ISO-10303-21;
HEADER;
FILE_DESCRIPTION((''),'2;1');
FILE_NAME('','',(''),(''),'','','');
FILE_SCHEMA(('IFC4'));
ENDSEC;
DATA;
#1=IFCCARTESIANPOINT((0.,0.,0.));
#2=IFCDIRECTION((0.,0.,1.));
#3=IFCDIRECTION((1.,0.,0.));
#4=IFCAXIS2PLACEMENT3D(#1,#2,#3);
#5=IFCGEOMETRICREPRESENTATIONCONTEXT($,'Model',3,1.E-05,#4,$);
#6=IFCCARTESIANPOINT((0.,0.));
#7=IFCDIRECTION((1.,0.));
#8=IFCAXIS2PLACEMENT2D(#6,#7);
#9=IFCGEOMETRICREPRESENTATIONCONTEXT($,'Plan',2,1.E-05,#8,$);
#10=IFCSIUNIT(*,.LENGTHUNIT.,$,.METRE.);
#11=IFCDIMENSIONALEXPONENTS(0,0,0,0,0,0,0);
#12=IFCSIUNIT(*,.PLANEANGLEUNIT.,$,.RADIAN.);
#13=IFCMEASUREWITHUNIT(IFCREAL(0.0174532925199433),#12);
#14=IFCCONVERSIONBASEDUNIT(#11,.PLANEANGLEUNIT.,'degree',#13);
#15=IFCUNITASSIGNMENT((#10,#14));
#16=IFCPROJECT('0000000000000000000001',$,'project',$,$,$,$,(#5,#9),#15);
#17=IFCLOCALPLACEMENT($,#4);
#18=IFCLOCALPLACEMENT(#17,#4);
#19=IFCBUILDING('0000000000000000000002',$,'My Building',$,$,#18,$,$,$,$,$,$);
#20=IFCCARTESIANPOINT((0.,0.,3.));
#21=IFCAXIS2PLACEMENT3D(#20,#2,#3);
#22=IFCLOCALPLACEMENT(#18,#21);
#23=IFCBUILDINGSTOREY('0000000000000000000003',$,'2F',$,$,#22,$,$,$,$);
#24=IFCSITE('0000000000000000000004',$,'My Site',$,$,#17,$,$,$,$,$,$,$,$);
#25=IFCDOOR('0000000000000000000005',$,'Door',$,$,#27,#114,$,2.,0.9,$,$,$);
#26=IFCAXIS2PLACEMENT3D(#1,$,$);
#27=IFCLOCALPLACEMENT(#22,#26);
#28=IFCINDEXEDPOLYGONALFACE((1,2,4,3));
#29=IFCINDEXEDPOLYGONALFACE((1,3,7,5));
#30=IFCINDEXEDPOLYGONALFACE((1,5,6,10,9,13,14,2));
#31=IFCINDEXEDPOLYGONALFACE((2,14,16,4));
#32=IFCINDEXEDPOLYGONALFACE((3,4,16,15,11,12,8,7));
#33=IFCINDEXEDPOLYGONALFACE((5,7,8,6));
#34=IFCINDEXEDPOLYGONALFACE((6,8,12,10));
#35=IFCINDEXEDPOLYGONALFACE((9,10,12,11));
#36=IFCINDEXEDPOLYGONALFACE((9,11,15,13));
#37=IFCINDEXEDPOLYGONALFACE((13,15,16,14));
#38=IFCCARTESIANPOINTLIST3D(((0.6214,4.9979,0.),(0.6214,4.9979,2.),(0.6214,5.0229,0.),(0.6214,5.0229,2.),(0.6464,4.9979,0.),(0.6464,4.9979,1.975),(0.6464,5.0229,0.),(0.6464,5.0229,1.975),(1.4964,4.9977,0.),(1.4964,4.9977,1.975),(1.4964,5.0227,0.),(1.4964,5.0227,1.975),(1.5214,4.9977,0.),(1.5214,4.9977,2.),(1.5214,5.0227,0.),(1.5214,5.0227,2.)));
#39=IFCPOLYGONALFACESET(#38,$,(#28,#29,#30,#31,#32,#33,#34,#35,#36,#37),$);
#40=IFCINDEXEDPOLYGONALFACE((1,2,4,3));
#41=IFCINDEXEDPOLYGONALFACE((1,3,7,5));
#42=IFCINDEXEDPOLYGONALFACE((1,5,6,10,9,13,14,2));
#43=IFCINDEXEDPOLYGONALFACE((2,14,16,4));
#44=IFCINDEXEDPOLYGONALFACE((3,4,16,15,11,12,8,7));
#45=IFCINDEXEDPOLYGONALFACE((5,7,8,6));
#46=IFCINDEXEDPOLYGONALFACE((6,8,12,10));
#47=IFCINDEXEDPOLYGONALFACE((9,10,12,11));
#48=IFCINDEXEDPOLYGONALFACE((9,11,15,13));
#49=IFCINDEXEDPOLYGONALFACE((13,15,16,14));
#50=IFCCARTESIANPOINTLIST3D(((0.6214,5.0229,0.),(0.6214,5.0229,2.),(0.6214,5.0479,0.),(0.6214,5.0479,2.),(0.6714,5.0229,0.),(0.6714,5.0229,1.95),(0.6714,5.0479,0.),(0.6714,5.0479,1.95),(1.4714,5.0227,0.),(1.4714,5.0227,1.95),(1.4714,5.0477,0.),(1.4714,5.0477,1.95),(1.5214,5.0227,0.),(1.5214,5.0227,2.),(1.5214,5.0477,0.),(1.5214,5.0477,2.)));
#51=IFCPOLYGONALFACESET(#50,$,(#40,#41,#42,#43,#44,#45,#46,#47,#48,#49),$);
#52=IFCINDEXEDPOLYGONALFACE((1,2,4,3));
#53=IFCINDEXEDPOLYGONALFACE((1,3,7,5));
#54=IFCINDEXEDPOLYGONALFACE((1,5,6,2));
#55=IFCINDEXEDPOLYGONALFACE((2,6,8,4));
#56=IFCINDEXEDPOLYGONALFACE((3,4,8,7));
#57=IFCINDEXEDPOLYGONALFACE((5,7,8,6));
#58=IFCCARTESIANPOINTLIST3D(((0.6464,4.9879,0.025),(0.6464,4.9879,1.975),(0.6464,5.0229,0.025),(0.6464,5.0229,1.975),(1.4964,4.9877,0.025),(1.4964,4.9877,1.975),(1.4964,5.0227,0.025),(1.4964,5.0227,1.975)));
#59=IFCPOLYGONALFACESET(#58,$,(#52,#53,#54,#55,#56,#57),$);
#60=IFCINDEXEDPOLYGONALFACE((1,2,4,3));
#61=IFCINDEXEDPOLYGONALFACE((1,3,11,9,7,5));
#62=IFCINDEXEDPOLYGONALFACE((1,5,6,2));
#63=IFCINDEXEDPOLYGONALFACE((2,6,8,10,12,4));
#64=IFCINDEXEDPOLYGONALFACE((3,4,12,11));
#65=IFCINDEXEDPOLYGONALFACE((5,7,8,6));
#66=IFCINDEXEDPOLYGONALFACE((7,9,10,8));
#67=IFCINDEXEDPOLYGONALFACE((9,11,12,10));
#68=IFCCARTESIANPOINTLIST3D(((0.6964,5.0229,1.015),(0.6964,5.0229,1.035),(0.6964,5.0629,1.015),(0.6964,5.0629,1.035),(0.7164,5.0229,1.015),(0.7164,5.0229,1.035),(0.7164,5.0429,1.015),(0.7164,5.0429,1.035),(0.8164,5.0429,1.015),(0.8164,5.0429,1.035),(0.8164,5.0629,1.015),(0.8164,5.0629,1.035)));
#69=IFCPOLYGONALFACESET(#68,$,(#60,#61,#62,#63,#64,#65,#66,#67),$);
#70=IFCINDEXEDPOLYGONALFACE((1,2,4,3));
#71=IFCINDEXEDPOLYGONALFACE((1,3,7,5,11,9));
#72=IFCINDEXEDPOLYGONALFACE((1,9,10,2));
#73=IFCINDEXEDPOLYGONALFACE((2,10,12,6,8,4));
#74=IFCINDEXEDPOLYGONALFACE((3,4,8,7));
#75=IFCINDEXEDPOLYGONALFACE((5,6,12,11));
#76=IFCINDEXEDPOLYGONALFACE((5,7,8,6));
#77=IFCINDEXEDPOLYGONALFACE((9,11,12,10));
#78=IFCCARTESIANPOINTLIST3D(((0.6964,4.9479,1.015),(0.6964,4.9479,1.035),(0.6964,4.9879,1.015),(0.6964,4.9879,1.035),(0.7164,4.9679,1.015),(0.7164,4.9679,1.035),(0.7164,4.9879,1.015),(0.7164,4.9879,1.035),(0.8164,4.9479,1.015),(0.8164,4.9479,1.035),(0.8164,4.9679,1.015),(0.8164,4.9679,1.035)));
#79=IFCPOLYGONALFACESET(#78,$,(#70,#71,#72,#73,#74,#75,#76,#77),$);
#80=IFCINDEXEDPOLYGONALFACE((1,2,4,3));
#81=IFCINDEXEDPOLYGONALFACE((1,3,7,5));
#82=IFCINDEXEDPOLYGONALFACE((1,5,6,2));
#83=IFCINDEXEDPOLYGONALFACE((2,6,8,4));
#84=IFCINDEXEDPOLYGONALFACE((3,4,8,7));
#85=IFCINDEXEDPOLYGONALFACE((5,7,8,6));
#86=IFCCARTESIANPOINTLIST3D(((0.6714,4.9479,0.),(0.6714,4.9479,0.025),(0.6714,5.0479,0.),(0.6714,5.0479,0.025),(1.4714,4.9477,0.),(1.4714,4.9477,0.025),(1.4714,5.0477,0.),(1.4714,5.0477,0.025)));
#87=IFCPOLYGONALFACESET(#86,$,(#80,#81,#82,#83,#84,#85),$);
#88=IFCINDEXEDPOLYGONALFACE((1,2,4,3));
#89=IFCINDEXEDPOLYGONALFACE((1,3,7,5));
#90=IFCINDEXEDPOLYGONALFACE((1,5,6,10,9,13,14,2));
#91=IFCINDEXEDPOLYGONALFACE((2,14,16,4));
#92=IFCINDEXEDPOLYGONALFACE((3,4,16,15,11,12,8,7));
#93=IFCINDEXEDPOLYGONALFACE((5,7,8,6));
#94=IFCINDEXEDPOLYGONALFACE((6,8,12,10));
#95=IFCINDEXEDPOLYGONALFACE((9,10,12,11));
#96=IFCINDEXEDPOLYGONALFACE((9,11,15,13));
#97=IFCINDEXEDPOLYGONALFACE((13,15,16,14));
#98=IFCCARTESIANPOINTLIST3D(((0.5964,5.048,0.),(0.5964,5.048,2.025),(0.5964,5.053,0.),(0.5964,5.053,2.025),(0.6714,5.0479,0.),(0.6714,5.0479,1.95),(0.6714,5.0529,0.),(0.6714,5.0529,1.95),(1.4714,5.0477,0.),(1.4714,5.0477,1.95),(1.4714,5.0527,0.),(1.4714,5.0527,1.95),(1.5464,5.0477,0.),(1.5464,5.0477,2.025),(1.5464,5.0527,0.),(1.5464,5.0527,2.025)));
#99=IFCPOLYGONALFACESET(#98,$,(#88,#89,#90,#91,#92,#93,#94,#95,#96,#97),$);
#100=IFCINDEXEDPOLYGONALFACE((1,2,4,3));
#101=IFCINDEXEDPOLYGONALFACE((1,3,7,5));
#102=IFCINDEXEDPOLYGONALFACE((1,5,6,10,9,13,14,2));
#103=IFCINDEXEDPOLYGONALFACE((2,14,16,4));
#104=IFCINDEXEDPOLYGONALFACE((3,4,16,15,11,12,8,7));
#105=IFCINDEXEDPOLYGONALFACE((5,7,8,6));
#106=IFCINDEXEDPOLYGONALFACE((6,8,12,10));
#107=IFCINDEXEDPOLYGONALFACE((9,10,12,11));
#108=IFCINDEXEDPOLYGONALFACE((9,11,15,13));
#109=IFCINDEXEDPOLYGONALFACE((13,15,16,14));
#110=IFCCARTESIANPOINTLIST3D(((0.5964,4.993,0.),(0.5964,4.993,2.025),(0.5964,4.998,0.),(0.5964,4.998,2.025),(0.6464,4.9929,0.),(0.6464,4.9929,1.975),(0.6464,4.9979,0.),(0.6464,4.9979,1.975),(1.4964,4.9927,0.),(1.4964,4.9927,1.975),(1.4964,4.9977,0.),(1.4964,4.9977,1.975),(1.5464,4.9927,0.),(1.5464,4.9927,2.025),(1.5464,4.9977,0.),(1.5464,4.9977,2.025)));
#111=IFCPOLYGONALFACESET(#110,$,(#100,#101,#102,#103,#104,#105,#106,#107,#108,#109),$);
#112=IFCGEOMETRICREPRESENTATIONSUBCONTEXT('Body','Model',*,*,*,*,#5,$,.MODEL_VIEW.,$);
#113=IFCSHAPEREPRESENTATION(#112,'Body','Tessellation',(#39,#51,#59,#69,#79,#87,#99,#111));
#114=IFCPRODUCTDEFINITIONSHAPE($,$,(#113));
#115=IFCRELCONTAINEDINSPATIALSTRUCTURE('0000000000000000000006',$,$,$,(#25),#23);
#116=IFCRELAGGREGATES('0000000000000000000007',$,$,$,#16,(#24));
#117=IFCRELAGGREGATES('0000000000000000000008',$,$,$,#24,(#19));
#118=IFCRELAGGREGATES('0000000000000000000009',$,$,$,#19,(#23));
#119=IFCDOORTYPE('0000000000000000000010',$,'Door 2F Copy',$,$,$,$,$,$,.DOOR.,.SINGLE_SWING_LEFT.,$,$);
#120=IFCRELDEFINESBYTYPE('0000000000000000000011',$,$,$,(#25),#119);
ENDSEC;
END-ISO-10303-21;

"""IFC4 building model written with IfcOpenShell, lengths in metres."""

from ifc_helpers import new_model, entity, si_unit, converted_unit, frame, origin_with_axes, origin_2d_with_axis, place, context, subcontext, project, spatial, line, indexed_curve, outline, extrude, shape, source, transform, mapped, type_object, type_shapes, element, save


model = new_model("IFC4")

# Units and contexts
model_context = context("Model", 3, precision=1e-05, world=origin_with_axes())
plan_context = context("Plan", 2, precision=1e-05, world=origin_2d_with_axis())
body_context_1 = subcontext(model_context, "Body", "Model", "MODEL_VIEW")
body_context_2 = subcontext(plan_context, "Body", "Plan", "PLAN_VIEW")
ifc_project = project(units=[si_unit("LENGTHUNIT", "METRE"), converted_unit("PLANEANGLEUNIT", "degree", entity("IfcReal", 0.0174532925199433), si_unit("PLANEANGLEUNIT", "RADIAN"), dimensions=[0, 0, 0, 0, 0, 0, 0])], contexts=[model_context, plan_context])

# Site, building, storey
site_placement = place(None, origin_with_axes())
site = spatial("IfcSite", under=ifc_project, at=site_placement, Name="My Site")
building_placement = place(site_placement, origin_with_axes())
building = spatial("IfcBuilding", under=site, at=building_placement, Name="My Building")
storey_placement = place(building_placement, frame((0.0, 0.0, 3.0), z_axis=(0.0, 0.0, 1.0), x_axis=(1.0, 0.0, 0.0)))
storey = spatial("IfcBuildingStorey", under=building, at=storey_placement, Name="2F")

# Door
placement_1 = place(storey_placement, frame((4.126, 5.047, 0.0), z_axis=(0.0, 0.0, 1.0), x_axis=(-1.0, 0.000274, 0.0)))
door_type_1 = type_object("IfcDoorType", Name="Door 2F Copy", OperationType="SINGLE_SWING_LEFT", PredefinedType="DOOR")
shared_shape_1 = source(origin_with_axes(), body_context_1, "Body", "SweptSolid", [
    extrude(outline(indexed_curve([(0.0, 0.0), (0.0, 2.0), (0.9, 2.0), (0.9, 0.0), (0.875, 0.0), (0.875, 1.975), (0.025, 1.975), (0.025, 0.0)], segments=[line(1, 2, 3, 4, 5, 6, 7, 8, 1)])), frame((0.0, 0.025, 0.0), z_axis=(0.0, -1.0, 0.0), x_axis=(1.0, 0.0, 0.0)), (0.0, 0.0, -1.0), 0.025),
    extrude(outline(indexed_curve([(0.0, 0.0), (0.0, 2.0), (0.9, 2.0), (0.9, 0.0), (0.85, 0.0), (0.85, 1.95), (0.05, 1.95), (0.05, 0.0)], segments=[line(1, 2, 3, 4, 5, 6, 7, 8, 1)])), frame((0.0, 0.0, 0.0), z_axis=(0.0, -1.0, 0.0), x_axis=(1.0, 0.0, 0.0)), (0.0, 0.0, -1.0), 0.025),
    extrude(outline(indexed_curve([(0.0, 0.0), (0.85, 0.0), (0.85, 0.035), (0.0, 0.035)], segments=[line(1, 2, 3, 4, 1)])), frame((0.025, 0.025, 0.025), z_axis=(0.0, 0.0, 1.0), x_axis=(1.0, 0.0, 0.0)), (0.0, 0.0, 1.0), 1.95),
    extrude(outline(indexed_curve([(0.0, 0.0), (0.0, -0.04), (-0.12, -0.04), (-0.12, -0.02), (-0.02, -0.02), (-0.02, 0.0)], segments=[line(1, 2, 3, 4, 5, 6, 1)])), frame((0.825, 0.025, 1.015), z_axis=(0.0, 0.0, 1.0), x_axis=(1.0, 0.0, 0.0)), (0.0, 0.0, 1.0), 0.02),
    extrude(outline(indexed_curve([(0.0, 0.0), (0.0, 0.04), (-0.12, 0.04), (-0.12, 0.02), (-0.02, 0.02), (-0.02, 0.0)], segments=[line(1, 2, 3, 4, 5, 6, 1)])), frame((0.825, 0.06, 1.015), z_axis=(0.0, 0.0, 1.0), x_axis=(1.0, 0.0, 0.0)), (0.0, 0.0, 1.0), 0.02),
    extrude(outline(indexed_curve([(0.0, 0.0), (0.8, 0.0), (0.8, 0.1), (0.0, 0.1)], segments=[line(1, 2, 3, 4, 1)])), frame((0.05, 0.0, 0.0), z_axis=(0.0, 0.0, 1.0), x_axis=(1.0, 0.0, 0.0)), (0.0, 0.0, 1.0), 0.025),
    extrude(outline(indexed_curve([(0.0, 0.0), (0.0, 2.025), (0.95, 2.025), (0.95, 0.0), (0.875, 0.0), (0.875, 1.95), (0.075, 1.95), (0.075, 0.0)], segments=[line(1, 2, 3, 4, 5, 6, 7, 8, 1)])), frame((-0.025, -0.005, 0.0), z_axis=(0.0, -1.0, 0.0), x_axis=(1.0, 0.0, 0.0)), (0.0, 0.0, -1.0), 0.005),
    extrude(outline(indexed_curve([(0.0, 0.0), (0.0, 2.025), (0.95, 2.025), (0.95, 0.0), (0.9, 0.0), (0.9, 1.975), (0.05, 1.975), (0.05, 0.0)], segments=[line(1, 2, 3, 4, 5, 6, 7, 8, 1)])), frame((-0.025, 0.05, 0.0), z_axis=(0.0, -1.0, 0.0), x_axis=(1.0, 0.0, 0.0)), (0.0, 0.0, -1.0), 0.005),
])
shared_shape_2 = source(origin_with_axes(), body_context_2, "Body", "Curve2D", [
    entity("IfcIndexedPolyCurve", entity("IfcCartesianPointList2D", [[0.0, 0.0], [0.0, 0.05], [0.025, 0.05], [0.025, 0.025], [0.05, 0.025], [0.05, 0.0]]), [entity("IfcLineIndex", [1, 2, 3, 4, 5, 6, 1])]),
    entity("IfcIndexedPolyCurve", entity("IfcCartesianPointList2D", [[0.9, 0.0], [0.9, 0.05], [0.875, 0.05], [0.875, 0.025], [0.85, 0.025], [0.85, 0.0]]), [entity("IfcLineIndex", [1, 2, 3, 4, 5, 6, 1])]),
    entity("IfcTrimmedCurve", entity("IfcEllipse", entity("IfcAxis2Placement2D", entity("IfcCartesianPoint", [0.06, 0.05]), entity("IfcDirection", [1.0, 0.0])), 0.815, 0.85), [entity("IfcCartesianPoint", [0.875, 0.05])], [entity("IfcCartesianPoint", [0.06, 0.9])], True, "CARTESIAN"),
    entity("IfcIndexedPolyCurve", entity("IfcCartesianPointList2D", [[0.025, 0.05], [0.06, 0.05], [0.06, 0.9], [0.025, 0.9]]), [entity("IfcLineIndex", [1, 2, 3, 4, 1])]),
])
type_shapes(door_type_1, [shared_shape_1, shared_shape_2])
placement_2 = place(placement_1, frame((2.6046, 0.0, 0.0), z_axis=(0.0, 0.0, 1.0), x_axis=(1.0, 0.0, 0.0)))
door_1_placement = place(placement_2, frame((0.0, 0.0, 0.0), z_axis=(0.0, 0.0, 1.0), x_axis=(1.0, 0.0, 0.0)))
element("IfcDoor", 1, at=door_1_placement, inside=storey, type_object=door_type_1, Name="Door", OverallHeight=2.0, OverallWidth=0.9, shapes=[
    shape(body_context_1, "Body", "MappedRepresentation", [mapped(shared_shape_1, transform((0.0, 0.0, 0.0), x_axis=(1.0, 0.0, 0.0), y_axis=(0.0, 1.0, 0.0), z_axis=(0.0, 0.0, 1.0), scale=1.0))]),
    shape(body_context_2, "Body", "MappedRepresentation", [mapped(shared_shape_2, transform((0.0, 0.0, 0.0), x_axis=(1.0, 0.0, 0.0), y_axis=(0.0, 1.0, 0.0), z_axis=(0.0, 0.0, 1.0), scale=1.0))]),
])

save(model, "model.ifc")
